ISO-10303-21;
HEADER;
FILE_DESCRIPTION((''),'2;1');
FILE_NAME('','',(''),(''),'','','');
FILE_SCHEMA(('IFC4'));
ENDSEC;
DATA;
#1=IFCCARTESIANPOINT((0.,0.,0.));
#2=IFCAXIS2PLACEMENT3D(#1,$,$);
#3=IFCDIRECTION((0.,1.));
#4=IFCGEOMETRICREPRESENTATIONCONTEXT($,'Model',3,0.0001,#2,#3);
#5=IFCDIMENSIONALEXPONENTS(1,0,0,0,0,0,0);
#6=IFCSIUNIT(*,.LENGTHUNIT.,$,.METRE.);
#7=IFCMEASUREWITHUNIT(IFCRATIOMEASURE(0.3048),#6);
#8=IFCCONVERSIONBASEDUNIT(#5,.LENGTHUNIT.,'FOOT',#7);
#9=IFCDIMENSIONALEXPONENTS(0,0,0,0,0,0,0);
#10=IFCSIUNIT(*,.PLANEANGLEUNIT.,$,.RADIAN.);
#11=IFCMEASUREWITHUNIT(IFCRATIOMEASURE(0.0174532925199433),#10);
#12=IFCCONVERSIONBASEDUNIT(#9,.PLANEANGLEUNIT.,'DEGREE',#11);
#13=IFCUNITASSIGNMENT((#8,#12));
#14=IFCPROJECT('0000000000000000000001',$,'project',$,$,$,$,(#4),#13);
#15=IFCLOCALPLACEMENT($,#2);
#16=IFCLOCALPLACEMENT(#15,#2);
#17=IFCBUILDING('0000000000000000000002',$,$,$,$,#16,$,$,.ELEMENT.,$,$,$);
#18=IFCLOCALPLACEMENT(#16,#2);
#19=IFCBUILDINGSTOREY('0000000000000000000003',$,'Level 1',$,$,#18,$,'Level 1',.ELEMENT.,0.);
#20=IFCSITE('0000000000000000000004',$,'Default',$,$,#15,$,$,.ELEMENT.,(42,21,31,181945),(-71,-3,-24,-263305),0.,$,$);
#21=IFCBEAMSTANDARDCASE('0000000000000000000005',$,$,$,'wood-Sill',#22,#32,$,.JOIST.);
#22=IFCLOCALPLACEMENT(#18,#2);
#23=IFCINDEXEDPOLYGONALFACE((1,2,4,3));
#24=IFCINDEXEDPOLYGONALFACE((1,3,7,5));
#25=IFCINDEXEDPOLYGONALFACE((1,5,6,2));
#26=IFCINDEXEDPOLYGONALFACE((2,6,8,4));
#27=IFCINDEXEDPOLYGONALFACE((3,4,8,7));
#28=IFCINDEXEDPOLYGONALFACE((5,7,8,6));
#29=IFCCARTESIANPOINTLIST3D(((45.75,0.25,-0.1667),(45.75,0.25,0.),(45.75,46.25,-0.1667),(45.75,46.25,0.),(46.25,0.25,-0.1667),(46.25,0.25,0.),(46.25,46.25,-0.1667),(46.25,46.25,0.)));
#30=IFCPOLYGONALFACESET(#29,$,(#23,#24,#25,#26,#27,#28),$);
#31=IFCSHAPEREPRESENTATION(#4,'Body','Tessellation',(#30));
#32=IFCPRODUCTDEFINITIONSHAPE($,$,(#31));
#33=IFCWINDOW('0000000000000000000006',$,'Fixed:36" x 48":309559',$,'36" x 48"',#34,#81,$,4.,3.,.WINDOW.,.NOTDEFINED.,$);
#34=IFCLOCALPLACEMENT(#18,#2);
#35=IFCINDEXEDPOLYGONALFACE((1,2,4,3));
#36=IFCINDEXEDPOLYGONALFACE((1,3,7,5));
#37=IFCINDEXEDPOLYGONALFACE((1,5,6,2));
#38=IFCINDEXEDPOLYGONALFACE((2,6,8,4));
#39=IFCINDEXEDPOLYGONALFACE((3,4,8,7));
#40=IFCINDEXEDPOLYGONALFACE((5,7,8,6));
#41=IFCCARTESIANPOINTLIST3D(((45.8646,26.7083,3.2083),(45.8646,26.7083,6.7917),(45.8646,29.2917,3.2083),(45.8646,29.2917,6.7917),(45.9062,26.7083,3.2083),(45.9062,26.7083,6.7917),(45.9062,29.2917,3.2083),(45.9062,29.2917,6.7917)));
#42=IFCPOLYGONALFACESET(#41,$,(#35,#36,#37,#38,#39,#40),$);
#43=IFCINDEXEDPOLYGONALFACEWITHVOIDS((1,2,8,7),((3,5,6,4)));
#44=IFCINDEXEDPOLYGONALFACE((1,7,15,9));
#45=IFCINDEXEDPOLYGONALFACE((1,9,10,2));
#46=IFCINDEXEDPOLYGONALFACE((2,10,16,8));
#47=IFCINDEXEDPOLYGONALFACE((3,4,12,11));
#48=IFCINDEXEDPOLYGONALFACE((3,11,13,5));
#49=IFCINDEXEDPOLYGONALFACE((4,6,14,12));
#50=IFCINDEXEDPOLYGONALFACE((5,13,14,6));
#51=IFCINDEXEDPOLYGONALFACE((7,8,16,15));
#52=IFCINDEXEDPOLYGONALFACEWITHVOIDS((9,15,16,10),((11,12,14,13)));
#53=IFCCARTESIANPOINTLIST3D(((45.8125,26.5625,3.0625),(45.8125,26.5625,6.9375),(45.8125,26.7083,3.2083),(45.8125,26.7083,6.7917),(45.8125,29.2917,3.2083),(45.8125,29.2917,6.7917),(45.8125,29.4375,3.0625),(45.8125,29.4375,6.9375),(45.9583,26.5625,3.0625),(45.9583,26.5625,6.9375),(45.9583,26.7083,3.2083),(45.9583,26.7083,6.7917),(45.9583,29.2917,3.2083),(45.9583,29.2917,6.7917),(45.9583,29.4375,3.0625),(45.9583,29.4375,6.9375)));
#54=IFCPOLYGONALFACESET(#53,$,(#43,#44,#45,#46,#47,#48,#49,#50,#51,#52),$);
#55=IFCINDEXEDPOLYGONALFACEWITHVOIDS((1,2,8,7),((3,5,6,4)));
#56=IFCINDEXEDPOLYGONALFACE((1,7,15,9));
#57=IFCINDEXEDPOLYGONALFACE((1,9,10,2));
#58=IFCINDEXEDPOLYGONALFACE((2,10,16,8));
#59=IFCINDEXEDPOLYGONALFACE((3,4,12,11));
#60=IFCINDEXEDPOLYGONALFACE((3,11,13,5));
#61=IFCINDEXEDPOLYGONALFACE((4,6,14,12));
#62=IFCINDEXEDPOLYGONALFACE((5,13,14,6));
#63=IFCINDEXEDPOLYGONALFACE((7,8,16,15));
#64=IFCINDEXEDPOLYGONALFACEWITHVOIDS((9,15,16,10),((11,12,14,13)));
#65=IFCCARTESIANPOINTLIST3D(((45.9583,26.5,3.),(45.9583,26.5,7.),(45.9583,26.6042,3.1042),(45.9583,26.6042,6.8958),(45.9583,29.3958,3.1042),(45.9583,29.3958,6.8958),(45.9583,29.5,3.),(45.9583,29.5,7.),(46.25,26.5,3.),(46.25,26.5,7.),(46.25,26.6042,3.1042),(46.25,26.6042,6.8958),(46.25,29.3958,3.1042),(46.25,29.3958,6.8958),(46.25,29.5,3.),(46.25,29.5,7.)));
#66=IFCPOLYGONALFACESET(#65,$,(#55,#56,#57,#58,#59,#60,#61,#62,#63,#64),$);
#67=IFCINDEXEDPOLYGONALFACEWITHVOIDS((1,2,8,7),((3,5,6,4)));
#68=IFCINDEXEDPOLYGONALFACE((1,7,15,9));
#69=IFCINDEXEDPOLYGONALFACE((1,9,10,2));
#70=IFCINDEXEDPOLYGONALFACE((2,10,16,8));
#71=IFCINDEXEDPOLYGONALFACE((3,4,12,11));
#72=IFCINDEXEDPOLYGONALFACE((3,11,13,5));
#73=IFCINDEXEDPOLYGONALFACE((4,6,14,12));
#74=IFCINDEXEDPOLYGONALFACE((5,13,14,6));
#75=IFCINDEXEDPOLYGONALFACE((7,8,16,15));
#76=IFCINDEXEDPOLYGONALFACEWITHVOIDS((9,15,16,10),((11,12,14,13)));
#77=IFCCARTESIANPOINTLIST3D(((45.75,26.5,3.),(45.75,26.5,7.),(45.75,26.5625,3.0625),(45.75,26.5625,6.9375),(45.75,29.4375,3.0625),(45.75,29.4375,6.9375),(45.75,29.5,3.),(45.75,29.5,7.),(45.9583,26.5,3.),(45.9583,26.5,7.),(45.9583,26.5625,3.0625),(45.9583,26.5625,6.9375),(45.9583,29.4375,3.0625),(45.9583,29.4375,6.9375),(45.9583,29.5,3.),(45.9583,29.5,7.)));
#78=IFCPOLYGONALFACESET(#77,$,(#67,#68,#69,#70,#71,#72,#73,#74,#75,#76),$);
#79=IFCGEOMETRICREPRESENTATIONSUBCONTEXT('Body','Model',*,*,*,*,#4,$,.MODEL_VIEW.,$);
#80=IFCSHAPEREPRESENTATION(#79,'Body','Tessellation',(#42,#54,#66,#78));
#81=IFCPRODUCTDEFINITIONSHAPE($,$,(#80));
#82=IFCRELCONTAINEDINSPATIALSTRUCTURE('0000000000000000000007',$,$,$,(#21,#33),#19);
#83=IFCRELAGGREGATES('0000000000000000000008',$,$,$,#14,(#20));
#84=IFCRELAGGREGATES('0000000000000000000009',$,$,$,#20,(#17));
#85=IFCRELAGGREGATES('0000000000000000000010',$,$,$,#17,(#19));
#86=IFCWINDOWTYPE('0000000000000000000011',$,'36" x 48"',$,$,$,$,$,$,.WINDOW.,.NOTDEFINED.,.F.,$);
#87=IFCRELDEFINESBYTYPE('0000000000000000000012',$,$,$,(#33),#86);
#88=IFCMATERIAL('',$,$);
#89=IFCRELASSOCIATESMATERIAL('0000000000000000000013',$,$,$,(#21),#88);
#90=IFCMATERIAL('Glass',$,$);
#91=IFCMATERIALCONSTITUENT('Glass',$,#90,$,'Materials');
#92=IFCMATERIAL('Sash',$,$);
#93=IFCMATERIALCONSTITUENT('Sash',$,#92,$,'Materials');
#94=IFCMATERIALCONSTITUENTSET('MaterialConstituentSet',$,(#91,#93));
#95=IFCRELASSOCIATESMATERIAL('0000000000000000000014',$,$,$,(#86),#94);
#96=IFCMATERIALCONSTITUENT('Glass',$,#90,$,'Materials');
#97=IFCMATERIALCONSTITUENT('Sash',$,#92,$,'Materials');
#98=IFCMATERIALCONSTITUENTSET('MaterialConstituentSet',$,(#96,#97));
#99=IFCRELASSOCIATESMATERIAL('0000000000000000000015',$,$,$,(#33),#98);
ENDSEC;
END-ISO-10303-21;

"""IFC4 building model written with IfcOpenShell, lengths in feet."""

from ifc_helpers import new_model, entity, si_unit, converted_unit, direction, frame, frame_2d, origin, place, context, subcontext, project, spatial, polyline, rectangle, outline, extrude, source, transform, mapped, material, constituent, constituent_set, type_object, type_shapes, element, save


model = new_model("IFC4")

# Units and contexts
model_context = context("Model", 3, precision=0.0001, world=origin(), true_north=direction((0.0, 1.0)))
body_context = subcontext(model_context, "Body", "Model", "MODEL_VIEW")
ifc_project = project(units=[converted_unit("LENGTHUNIT", "FOOT", entity("IfcRatioMeasure", 0.3048), si_unit("LENGTHUNIT", "METRE"), dimensions=[1, 0, 0, 0, 0, 0, 0]), converted_unit("PLANEANGLEUNIT", "DEGREE", entity("IfcRatioMeasure", 0.0174532925199433), si_unit("PLANEANGLEUNIT", "RADIAN"), dimensions=[0, 0, 0, 0, 0, 0, 0])], contexts=[model_context])

# Site, building, storey
site_placement = place(None, origin())
site = spatial("IfcSite", under=ifc_project, at=site_placement, Name="Default", CompositionType="ELEMENT", RefLatitude=(42, 21, 31, 181945), RefLongitude=(-71, -3, -24, -263305), RefElevation=0.0)
building_placement = place(site_placement, origin())
building = spatial("IfcBuilding", under=site, at=building_placement, CompositionType="ELEMENT")
storey_placement = place(building_placement, origin())
storey = spatial("IfcBuildingStorey", under=building, at=storey_placement, Name="Level 1", LongName="Level 1", CompositionType="ELEMENT", Elevation=0.0)

# Shared definitions
placement_1 = place(storey_placement, frame((46.0, 46.25, 0.0), z_axis=(0.0, 0.0, 1.0), x_axis=(0.0, -1.0, 0.0)))

# Beam
ifc_material_1 = material(Name="")
beam_1_placement = place(placement_1, frame((23.0, 0.0, -0.1667), z_axis=(0.0, 0.0, 1.0), x_axis=(1.0, 0.0, 0.0)))
element("IfcBeamStandardCase", 1, at=beam_1_placement, inside=storey, material=ifc_material_1, ObjectType="wood-Sill", PredefinedType="JOIST", context=model_context, shape_type="SweptSolid", body=[
    extrude(rectangle(XDim=46.0, YDim=0.5), origin(), (0.0, 0.0, 1.0), 0.1667),
])

# Window
ifc_material_2 = material(Name="Glass")
ifc_constituent_1 = constituent(ifc_material_2, Name="Glass", Category="Materials")
ifc_material_3 = material(Name="Sash")
ifc_constituent_2 = constituent(ifc_material_3, Name="Sash", Category="Materials")
ifc_constituent_set_1 = constituent_set(constituents=[ifc_constituent_1, ifc_constituent_2], Name="MaterialConstituentSet")
ifc_constituent_3 = constituent(ifc_material_2, Name="Glass", Category="Materials")
ifc_constituent_4 = constituent(ifc_material_3, Name="Sash", Category="Materials")
ifc_constituent_set_2 = constituent_set(constituents=[ifc_constituent_3, ifc_constituent_4], Name="MaterialConstituentSet")
window_type = type_object("IfcWindowType", Name="36\" x 48\"", ParameterTakesPrecedence=False, PartitioningType="NOTDEFINED", PredefinedType="WINDOW", material=ifc_constituent_set_2)
shared_shape = source(origin(), body_context, "Body", "SweptSolid", [
    extrude(rectangle(XDim=0.0417, YDim=2.5833, at=frame_2d((0.0, 0.0), x_axis=(1.0, 0.0))), frame((1.5, 0.3646, 0.2083), z_axis=(0.0, 0.0, 1.0), x_axis=(0.0, 1.0, 0.0)), (0.0, 0.0, 1.0), 3.5833),
    extrude(outline(polyline([(-1.4375, -1.9375), (1.4375, -1.9375), (1.4375, 1.9375), (-1.4375, 1.9375), (-1.4375, -1.9375)]), holes=[polyline([(-1.2917, -1.7917), (-1.2917, 1.7917), (1.2917, 1.7917), (1.2917, -1.7917), (-1.2917, -1.7917)])]), frame((1.5, 0.2917, 2.0), z_axis=(0.0, 1.0, 0.0), x_axis=(1.0, 0.0, 0.0)), (0.0, 0.0, 1.0), 0.1458),
    extrude(outline(polyline([(-1.5, -2.0), (1.5, -2.0), (1.5, 2.0), (-1.5, 2.0), (-1.5, -2.0)]), holes=[polyline([(-1.3958, -1.8958), (-1.3958, 1.8958), (1.3958, 1.8958), (1.3958, -1.8958), (-1.3958, -1.8958)])]), frame((1.5, 0.0, 2.0), z_axis=(0.0, 1.0, 0.0), x_axis=(1.0, 0.0, 0.0)), (0.0, 0.0, 1.0), 0.2917),
    extrude(outline(polyline([(-2.0, -1.5), (2.0, -1.5), (2.0, 1.5), (-2.0, 1.5), (-2.0, -1.5)]), holes=[polyline([(-1.9375, -1.4375), (-1.9375, 1.4375), (1.9375, 1.4375), (1.9375, -1.4375), (-1.9375, -1.4375)])]), frame((1.5, 0.2917, 2.0), z_axis=(0.0, 1.0, 0.0), x_axis=(0.0, 0.0, -1.0)), (0.0, 0.0, 1.0), 0.2083),
])
type_shapes(window_type, [shared_shape])
placement_2 = place(placement_1, frame((19.75, 0.25, 3.0)))
window_placement = place(placement_2, frame((0.0, 0.0, 0.0), z_axis=(0.0, 0.0, 1.0), x_axis=(-1.0, 0.0, 0.0)))
element("IfcWindow", 2, at=window_placement, inside=storey, type_object=window_type, material=ifc_constituent_set_1, Name="Fixed:36\" x 48\":309559", ObjectType="36\" x 48\"", OverallHeight=4.0, OverallWidth=3.0, PartitioningType="NOTDEFINED", PredefinedType="WINDOW", context=body_context, shape_type="MappedRepresentation", body=[
    mapped(shared_shape, transform((0.0, 0.0, 0.0), scale=1.0)),
])

save(model, "model.ifc")
